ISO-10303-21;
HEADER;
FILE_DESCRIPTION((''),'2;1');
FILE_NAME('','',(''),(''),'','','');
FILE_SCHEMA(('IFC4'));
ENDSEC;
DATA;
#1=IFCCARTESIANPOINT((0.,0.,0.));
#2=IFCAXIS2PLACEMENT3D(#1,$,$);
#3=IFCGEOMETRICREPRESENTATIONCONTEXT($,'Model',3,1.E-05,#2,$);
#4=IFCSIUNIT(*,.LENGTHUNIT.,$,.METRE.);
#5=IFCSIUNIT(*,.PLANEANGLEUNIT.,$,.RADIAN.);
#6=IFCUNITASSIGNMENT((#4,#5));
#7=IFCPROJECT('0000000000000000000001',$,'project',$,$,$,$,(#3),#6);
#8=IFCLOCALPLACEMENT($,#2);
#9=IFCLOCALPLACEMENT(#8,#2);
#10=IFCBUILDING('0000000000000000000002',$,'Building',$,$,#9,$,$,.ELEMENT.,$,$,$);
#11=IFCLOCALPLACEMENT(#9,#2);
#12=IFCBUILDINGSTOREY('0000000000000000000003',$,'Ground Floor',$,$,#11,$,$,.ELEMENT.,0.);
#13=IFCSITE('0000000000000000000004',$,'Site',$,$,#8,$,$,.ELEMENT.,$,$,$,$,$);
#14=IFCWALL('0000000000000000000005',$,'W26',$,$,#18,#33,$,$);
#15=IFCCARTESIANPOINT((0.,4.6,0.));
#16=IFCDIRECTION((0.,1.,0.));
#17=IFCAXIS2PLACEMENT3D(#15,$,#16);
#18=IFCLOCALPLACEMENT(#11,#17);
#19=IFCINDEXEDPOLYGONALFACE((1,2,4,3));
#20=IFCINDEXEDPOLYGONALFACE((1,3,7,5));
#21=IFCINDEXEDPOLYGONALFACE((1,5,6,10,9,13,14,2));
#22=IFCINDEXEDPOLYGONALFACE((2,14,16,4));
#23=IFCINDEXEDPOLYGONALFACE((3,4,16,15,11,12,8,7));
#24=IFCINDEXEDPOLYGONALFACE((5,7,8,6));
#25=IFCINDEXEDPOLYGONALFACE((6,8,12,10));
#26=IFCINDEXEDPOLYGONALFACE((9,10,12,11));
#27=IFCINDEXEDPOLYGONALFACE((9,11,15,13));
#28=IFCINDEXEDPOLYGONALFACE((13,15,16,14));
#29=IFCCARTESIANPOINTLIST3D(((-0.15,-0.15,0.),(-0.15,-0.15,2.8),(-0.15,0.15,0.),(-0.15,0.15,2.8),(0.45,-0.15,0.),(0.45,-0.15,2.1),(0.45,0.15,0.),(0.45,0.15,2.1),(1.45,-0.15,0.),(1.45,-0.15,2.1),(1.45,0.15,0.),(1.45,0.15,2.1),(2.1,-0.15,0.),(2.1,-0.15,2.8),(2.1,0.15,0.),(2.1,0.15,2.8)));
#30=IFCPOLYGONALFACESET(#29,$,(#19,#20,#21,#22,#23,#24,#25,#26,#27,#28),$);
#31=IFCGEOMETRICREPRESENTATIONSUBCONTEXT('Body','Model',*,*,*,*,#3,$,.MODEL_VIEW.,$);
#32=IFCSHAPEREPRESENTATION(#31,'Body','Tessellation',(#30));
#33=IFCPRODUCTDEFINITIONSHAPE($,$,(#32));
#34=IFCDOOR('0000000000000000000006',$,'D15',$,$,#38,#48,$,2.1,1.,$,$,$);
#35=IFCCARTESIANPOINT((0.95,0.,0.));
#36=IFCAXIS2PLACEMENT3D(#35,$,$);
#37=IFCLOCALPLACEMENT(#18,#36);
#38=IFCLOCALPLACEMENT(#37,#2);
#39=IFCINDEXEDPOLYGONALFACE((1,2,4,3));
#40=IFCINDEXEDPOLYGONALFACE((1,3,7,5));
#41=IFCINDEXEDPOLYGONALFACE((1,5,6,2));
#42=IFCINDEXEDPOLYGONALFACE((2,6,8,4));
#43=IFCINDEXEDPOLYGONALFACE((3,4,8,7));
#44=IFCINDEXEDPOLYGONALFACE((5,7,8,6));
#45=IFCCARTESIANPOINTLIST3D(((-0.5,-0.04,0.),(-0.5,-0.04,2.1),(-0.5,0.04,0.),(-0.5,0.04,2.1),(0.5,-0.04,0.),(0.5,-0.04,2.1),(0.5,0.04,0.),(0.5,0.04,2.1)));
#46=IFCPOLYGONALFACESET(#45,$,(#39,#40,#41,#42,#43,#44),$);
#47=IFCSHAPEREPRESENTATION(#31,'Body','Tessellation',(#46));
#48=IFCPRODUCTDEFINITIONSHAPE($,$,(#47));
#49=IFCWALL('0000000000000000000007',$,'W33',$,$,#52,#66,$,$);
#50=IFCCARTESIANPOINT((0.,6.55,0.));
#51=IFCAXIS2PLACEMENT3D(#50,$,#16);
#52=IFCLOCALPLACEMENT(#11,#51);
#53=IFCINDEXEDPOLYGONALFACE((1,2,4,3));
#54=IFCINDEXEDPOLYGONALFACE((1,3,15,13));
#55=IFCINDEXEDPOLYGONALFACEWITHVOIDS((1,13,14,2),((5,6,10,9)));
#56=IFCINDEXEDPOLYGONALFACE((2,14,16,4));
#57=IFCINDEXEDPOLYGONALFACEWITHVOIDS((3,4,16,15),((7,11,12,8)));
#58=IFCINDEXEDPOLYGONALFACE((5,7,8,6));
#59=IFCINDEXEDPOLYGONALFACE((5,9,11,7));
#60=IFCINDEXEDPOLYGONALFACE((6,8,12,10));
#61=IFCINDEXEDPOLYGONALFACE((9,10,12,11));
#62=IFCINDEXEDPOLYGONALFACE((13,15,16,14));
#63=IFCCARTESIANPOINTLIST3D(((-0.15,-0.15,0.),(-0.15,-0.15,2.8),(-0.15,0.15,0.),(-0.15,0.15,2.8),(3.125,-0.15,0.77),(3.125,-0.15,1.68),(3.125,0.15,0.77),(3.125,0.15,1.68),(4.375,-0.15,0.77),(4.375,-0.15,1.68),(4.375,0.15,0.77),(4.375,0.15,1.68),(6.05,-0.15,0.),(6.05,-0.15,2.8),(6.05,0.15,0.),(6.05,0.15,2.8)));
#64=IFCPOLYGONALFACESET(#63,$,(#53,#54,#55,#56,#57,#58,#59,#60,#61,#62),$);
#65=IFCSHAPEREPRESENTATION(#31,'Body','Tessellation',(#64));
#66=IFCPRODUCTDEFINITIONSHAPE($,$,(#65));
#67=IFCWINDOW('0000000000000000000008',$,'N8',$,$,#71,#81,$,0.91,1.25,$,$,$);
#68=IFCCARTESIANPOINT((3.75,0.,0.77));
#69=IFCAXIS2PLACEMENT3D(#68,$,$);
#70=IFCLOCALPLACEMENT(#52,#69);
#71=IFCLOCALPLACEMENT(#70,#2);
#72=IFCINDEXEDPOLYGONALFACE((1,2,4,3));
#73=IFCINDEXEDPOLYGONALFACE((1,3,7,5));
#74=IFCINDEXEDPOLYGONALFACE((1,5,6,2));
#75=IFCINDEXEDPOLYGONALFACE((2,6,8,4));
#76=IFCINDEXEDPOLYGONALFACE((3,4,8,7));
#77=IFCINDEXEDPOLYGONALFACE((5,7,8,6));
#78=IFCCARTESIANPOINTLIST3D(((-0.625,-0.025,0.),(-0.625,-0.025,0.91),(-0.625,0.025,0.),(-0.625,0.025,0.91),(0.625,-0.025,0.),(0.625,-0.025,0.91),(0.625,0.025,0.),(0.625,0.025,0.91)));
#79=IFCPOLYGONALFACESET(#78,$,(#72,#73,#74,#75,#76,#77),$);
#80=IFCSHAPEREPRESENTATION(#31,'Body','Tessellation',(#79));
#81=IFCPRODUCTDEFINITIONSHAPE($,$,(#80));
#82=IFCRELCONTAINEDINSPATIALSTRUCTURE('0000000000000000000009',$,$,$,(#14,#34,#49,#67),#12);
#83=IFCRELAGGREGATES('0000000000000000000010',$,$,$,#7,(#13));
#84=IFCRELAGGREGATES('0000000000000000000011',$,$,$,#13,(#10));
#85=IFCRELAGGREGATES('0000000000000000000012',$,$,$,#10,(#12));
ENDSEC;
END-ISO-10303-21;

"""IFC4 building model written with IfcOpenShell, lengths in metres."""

from ifc_helpers import new_model, si_unit, frame, frame_2d, origin, origin_2d, place, context, subcontext, project, spatial, rectangle, extrude, element, fill, save


model = new_model("IFC4")

# Units and contexts
model_context = context("Model", 3, precision=1e-05, world=origin())
body_context = subcontext(model_context, "Body", "Model", "MODEL_VIEW")
ifc_project = project(units=[si_unit("LENGTHUNIT", "METRE"), si_unit("PLANEANGLEUNIT", "RADIAN")], contexts=[model_context])

# Site, building, storey
site_placement = place(None, origin())
site = spatial("IfcSite", under=ifc_project, at=site_placement, Name="Site", CompositionType="ELEMENT")
building_placement = place(site_placement, origin())
building = spatial("IfcBuilding", under=site, at=building_placement, Name="Building", CompositionType="ELEMENT")
storey_placement = place(building_placement, origin())
storey = spatial("IfcBuildingStorey", under=building, at=storey_placement, Name="Ground Floor", CompositionType="ELEMENT", Elevation=0.0)

# Wall, opening, door
wall_1_placement = place(storey_placement, frame((0.0, 4.6, 0.0), x_axis=(0.0, 1.0, 0.0)))
wall_1 = element("IfcWall", 1, at=wall_1_placement, inside=storey, Name="W26", context=body_context, shape_type="SweptSolid", body=[
    extrude(rectangle(XDim=2.25, YDim=0.3, at=frame_2d((0.975, 0.0))), origin(), (0.0, 0.0, 1.0), 2.8),
])
opening_1_placement = place(wall_1_placement, frame((0.95, 0.0, 0.0)))
opening_1 = element("IfcOpeningElement", 2, at=opening_1_placement, cuts=wall_1, context=body_context, shape_type="SweptSolid", body=[
    extrude(rectangle(XDim=1.0, YDim=0.4, at=origin_2d()), origin(), (0.0, 0.0, 1.0), 2.1),
])
door_1_placement = place(opening_1_placement, origin())
door_1 = element("IfcDoor", 3, at=door_1_placement, inside=storey, Name="D15", OverallHeight=2.1, OverallWidth=1.0, context=body_context, shape_type="SweptSolid", body=[
    extrude(rectangle(XDim=1.0, YDim=0.08, at=origin_2d()), origin(), (0.0, 0.0, 1.0), 2.1),
])
fill(opening_1, door_1)

# Wall, opening, window
wall_2_placement = place(storey_placement, frame((0.0, 6.55, 0.0), x_axis=(0.0, 1.0, 0.0)))
wall_2 = element("IfcWall", 4, at=wall_2_placement, inside=storey, Name="W33", context=body_context, shape_type="SweptSolid", body=[
    extrude(rectangle(XDim=6.2, YDim=0.3, at=frame_2d((2.95, 0.0))), origin(), (0.0, 0.0, 1.0), 2.8),
])
opening_2_placement = place(wall_2_placement, frame((3.75, 0.0, 0.77)))
opening_2 = element("IfcOpeningElement", 5, at=opening_2_placement, cuts=wall_2, context=body_context, shape_type="SweptSolid", body=[
    extrude(rectangle(XDim=1.25, YDim=0.4, at=origin_2d()), origin(), (0.0, 0.0, 1.0), 0.91),
])
window_1_placement = place(opening_2_placement, origin())
window_1 = element("IfcWindow", 6, at=window_1_placement, inside=storey, Name="N8", OverallHeight=0.91, OverallWidth=1.25, context=body_context, shape_type="SweptSolid", body=[
    extrude(rectangle(XDim=1.25, YDim=0.05, at=origin_2d()), origin(), (0.0, 0.0, 1.0), 0.91),
])
fill(opening_2, window_1)

save(model, "model.ifc")
